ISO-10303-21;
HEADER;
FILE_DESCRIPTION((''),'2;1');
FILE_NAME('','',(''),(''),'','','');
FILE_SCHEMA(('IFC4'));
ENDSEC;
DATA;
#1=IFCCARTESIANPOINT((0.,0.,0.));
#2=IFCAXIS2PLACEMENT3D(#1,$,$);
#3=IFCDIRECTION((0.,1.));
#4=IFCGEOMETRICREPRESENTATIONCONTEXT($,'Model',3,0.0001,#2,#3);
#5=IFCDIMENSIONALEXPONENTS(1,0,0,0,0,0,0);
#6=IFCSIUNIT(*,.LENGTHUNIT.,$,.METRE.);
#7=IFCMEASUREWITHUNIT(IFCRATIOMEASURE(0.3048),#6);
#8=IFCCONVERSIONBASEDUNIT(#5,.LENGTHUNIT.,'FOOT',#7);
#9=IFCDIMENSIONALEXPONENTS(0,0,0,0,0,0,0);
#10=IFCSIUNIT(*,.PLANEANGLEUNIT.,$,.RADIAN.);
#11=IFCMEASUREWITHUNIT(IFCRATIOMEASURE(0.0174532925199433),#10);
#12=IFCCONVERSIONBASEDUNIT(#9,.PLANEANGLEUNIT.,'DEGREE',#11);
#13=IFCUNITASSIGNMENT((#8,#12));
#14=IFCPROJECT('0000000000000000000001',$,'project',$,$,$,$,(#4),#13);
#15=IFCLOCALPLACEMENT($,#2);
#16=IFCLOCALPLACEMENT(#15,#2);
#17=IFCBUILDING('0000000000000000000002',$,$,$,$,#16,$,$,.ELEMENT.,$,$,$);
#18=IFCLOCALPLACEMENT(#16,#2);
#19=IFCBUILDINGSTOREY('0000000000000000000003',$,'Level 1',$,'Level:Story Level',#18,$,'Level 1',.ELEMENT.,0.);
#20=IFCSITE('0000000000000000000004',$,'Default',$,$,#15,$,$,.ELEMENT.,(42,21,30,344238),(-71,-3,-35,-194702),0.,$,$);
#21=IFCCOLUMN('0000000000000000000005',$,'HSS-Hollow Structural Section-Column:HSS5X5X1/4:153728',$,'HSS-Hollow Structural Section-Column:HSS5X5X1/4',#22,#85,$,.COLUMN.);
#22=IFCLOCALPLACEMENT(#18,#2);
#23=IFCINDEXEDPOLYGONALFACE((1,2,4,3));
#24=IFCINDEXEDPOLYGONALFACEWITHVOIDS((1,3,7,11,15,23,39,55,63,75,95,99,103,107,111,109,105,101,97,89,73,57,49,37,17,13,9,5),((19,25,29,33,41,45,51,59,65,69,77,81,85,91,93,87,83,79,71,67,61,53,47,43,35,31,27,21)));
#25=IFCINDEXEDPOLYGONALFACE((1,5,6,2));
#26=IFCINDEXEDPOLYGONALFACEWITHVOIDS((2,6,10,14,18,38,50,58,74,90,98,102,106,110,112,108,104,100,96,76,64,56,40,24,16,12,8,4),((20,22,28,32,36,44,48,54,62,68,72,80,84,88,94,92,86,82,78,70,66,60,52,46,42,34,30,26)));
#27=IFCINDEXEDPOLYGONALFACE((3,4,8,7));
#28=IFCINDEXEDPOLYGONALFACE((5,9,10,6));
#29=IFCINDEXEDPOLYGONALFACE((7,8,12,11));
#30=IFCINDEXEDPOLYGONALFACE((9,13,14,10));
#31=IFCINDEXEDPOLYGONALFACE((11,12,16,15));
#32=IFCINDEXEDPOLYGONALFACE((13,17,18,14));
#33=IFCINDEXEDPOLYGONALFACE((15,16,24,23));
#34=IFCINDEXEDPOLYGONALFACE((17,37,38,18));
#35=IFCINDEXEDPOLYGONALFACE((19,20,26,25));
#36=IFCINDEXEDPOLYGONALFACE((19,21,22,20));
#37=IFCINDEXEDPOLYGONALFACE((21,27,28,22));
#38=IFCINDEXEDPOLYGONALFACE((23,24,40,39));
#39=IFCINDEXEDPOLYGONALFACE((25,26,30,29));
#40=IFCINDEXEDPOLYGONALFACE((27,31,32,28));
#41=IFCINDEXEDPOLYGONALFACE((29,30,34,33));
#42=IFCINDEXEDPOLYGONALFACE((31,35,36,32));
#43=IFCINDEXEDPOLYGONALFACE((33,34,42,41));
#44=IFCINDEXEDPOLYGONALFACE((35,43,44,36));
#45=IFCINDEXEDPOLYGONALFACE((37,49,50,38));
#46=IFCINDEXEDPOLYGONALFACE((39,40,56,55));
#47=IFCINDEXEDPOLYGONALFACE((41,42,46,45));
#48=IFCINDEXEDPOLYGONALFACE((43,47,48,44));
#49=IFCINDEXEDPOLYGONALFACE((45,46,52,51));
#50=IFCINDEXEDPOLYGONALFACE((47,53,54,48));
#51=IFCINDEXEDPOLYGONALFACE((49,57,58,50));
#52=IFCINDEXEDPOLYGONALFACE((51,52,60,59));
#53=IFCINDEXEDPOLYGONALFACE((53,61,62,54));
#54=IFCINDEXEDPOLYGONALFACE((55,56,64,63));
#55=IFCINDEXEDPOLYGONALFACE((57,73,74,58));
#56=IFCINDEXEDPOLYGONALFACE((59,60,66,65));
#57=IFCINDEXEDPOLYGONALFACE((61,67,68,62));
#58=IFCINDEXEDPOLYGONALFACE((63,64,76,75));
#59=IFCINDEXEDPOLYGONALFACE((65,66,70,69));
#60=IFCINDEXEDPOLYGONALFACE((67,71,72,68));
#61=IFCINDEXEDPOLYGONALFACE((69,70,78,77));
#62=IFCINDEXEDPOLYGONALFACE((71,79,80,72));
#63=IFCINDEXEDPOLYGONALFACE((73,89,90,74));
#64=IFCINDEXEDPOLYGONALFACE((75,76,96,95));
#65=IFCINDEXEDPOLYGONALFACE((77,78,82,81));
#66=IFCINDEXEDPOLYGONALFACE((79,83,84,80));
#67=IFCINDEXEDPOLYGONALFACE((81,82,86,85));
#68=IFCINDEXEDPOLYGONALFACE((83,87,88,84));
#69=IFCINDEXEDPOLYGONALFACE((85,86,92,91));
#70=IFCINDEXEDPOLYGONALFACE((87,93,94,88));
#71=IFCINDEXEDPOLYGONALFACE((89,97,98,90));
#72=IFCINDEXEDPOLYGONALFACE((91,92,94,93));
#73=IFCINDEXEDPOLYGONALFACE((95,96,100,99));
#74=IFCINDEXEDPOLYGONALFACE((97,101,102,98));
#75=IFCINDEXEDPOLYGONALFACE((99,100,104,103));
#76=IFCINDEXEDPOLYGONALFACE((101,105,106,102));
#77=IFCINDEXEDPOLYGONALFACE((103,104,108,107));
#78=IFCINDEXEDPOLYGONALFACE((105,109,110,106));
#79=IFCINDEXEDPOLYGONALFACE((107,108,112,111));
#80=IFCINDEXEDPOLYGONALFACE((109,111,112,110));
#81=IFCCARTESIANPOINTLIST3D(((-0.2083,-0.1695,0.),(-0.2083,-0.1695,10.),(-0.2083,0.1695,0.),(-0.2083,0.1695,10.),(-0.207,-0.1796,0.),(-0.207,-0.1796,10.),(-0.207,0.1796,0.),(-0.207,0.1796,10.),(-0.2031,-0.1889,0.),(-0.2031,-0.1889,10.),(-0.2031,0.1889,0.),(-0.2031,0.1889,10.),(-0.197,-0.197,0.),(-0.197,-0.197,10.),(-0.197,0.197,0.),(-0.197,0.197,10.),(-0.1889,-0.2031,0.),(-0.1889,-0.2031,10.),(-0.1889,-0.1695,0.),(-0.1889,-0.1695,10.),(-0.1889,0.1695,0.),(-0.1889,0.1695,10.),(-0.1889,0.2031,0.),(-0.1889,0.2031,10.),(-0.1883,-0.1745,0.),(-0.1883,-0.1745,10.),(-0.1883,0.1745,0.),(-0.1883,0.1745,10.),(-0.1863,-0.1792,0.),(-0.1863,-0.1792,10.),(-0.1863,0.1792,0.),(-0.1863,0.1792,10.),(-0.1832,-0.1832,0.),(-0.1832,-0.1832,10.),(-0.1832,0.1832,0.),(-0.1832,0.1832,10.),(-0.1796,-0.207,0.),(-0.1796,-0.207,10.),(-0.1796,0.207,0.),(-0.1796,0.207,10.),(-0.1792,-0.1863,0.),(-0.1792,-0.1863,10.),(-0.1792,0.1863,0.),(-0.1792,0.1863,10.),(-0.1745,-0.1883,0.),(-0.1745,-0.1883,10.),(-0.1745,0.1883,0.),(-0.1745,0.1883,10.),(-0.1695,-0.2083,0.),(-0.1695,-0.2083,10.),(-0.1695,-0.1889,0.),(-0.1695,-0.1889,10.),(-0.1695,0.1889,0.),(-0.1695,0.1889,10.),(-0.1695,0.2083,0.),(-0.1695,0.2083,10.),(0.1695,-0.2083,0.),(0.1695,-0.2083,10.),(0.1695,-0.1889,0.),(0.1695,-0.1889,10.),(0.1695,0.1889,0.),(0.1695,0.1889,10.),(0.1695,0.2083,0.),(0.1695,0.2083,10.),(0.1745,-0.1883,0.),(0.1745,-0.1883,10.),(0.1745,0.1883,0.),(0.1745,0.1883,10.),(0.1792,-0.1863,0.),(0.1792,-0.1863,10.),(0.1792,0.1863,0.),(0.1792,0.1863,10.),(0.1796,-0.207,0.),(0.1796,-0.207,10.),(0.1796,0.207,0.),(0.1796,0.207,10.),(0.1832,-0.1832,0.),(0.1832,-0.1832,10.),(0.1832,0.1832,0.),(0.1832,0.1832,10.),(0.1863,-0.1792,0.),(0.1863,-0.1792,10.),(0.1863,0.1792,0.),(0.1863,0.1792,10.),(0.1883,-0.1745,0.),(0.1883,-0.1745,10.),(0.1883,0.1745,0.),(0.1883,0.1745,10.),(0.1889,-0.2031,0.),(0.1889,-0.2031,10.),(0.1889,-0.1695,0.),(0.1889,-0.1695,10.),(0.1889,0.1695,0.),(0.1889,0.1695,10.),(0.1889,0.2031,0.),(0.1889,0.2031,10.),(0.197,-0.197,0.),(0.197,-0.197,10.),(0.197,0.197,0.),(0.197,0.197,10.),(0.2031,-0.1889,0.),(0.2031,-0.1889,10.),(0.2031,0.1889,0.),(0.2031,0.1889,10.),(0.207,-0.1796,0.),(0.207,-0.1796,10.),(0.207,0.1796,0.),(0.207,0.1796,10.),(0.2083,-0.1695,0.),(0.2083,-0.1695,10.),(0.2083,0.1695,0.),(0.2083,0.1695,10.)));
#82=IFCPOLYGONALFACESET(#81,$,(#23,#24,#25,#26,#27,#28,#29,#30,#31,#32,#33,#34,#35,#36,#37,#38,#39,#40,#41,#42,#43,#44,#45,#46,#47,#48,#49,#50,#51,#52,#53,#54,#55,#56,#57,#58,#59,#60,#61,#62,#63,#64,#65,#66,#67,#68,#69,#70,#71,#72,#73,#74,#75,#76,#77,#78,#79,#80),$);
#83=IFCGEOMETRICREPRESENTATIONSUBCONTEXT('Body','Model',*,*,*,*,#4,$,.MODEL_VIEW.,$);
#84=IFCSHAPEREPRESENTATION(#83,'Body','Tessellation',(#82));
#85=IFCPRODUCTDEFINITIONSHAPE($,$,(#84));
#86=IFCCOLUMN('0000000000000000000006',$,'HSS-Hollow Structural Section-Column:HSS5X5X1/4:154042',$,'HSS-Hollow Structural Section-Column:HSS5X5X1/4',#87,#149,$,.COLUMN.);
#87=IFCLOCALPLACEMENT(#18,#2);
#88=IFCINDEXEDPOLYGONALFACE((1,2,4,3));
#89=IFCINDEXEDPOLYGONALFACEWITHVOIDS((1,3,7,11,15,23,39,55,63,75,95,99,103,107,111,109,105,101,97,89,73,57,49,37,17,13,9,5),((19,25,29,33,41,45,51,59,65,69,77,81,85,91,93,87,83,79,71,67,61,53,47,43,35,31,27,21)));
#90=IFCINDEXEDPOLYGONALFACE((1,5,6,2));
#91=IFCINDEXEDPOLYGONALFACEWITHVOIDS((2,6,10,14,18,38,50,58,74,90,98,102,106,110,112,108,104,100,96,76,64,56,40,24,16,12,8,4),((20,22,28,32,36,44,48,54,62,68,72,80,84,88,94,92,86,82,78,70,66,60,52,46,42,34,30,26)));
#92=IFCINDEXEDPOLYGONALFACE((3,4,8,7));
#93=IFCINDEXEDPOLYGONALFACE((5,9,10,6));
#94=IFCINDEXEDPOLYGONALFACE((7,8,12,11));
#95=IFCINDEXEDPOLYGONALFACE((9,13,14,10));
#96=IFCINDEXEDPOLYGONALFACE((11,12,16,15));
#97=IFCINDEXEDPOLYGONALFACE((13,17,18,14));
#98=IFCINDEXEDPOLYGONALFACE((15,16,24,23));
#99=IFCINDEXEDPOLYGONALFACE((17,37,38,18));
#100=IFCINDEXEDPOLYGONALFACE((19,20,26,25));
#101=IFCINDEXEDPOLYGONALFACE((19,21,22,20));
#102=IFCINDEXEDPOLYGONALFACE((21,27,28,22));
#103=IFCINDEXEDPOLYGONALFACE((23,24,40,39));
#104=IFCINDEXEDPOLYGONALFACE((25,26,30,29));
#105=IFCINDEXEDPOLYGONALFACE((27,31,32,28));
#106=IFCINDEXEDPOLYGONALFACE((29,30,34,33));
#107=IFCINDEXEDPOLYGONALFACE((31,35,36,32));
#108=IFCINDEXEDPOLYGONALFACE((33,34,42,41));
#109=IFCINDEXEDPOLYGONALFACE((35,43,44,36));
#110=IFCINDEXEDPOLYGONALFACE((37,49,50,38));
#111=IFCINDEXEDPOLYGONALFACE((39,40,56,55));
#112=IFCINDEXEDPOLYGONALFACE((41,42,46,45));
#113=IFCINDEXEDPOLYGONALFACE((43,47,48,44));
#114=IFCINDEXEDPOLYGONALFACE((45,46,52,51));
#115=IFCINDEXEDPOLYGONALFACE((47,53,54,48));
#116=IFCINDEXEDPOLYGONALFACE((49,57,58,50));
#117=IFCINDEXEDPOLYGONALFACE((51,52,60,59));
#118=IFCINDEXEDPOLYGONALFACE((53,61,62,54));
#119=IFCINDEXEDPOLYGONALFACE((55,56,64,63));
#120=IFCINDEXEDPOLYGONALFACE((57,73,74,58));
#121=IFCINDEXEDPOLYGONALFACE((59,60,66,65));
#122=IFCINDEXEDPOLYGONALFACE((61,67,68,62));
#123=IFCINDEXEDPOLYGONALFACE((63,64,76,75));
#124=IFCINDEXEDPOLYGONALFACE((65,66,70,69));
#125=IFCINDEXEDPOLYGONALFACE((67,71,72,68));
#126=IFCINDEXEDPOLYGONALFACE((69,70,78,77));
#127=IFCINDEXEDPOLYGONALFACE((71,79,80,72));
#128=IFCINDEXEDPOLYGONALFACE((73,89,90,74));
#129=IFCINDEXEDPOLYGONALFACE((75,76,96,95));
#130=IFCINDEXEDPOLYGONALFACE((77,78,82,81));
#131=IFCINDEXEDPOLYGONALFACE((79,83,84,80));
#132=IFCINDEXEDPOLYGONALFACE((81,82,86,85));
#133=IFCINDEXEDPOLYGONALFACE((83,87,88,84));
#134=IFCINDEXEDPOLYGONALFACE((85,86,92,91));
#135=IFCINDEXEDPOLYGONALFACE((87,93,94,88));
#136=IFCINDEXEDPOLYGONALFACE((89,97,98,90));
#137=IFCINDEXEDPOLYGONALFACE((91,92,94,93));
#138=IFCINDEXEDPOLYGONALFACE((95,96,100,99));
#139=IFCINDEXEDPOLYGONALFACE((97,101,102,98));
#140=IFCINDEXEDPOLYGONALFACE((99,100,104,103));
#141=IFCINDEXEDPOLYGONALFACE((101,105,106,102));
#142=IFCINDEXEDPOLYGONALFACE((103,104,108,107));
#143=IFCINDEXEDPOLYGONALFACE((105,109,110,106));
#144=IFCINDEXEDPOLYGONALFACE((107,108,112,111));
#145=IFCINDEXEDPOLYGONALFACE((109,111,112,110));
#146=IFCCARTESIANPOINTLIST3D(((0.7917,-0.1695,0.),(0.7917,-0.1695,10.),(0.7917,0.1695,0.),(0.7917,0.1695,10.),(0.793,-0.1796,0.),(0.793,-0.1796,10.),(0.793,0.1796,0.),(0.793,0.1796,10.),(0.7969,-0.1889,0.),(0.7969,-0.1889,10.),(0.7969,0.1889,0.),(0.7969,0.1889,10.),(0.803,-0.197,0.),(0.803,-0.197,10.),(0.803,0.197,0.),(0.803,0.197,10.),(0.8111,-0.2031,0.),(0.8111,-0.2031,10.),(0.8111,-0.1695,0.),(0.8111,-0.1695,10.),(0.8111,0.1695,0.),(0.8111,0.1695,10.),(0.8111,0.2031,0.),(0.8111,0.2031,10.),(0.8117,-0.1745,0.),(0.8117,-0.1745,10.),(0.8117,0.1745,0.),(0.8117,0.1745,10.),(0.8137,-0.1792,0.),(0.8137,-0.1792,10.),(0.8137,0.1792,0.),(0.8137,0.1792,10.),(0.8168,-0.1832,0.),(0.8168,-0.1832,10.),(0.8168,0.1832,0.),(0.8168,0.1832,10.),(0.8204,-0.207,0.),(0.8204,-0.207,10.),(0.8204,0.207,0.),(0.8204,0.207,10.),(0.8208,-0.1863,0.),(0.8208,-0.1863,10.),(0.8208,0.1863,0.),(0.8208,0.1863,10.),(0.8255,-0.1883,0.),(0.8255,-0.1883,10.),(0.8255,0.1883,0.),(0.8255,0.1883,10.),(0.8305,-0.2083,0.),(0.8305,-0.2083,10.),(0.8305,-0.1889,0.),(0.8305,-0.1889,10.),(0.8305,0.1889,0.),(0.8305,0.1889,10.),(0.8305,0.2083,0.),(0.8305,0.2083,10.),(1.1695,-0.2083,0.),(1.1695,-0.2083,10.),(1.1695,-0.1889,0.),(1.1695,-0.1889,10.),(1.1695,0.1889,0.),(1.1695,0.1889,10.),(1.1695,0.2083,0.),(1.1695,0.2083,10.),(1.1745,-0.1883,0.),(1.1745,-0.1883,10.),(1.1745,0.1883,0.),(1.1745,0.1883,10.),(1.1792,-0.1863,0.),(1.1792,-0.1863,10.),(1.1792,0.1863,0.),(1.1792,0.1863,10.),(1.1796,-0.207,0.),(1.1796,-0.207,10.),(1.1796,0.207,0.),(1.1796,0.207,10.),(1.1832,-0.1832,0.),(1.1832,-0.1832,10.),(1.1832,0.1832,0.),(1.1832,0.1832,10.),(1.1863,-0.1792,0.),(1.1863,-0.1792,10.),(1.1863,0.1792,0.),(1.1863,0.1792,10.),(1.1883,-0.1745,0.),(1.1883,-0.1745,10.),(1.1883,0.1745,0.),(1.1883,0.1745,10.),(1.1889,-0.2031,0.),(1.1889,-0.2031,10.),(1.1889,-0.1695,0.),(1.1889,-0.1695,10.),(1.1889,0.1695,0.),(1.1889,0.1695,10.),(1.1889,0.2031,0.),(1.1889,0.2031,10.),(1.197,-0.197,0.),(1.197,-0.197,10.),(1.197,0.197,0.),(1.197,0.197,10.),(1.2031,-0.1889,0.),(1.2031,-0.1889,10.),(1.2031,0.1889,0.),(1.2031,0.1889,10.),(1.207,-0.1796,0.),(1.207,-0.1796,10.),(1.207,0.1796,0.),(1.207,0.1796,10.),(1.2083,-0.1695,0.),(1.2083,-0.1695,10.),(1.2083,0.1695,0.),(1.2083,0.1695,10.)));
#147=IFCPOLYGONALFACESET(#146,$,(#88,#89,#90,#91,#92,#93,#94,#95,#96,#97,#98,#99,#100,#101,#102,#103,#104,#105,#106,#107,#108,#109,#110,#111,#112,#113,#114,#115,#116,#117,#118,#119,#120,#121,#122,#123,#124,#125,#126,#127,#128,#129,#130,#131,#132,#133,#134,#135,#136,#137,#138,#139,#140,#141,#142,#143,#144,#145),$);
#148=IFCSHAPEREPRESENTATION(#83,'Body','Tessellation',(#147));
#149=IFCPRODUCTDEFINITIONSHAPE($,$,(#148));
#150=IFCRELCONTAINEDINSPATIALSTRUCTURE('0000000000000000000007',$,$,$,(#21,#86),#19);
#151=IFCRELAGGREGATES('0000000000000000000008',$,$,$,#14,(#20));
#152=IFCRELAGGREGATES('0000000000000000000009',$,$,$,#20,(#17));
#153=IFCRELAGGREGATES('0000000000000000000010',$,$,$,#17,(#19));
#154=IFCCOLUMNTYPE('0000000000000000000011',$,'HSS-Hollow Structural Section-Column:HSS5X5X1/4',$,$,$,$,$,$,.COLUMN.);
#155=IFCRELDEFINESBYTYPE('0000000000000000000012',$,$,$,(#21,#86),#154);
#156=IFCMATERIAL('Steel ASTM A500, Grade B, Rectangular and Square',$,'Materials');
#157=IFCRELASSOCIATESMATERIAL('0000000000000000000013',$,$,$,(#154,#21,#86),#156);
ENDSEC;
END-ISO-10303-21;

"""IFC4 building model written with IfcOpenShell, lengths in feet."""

from ifc_helpers import new_model, entity, si_unit, converted_unit, direction, frame, frame_2d, origin, place, context, subcontext, project, spatial, polyline, circle_curve, parameter, trimmed, segment, composite_curve, outline, extrude, source, transform, mapped, material, material_profile, profile_set, profile_usage, type_object, type_shapes, element, save


model = new_model("IFC4")

# Units and contexts
model_context = context("Model", 3, precision=0.0001, world=origin(), true_north=direction((0.0, 1.0)))
body_context = subcontext(model_context, "Body", "Model", "MODEL_VIEW")
ifc_project = project(units=[converted_unit("LENGTHUNIT", "FOOT", entity("IfcRatioMeasure", 0.3048), si_unit("LENGTHUNIT", "METRE"), dimensions=[1, 0, 0, 0, 0, 0, 0]), converted_unit("PLANEANGLEUNIT", "DEGREE", entity("IfcRatioMeasure", 0.0174532925199433), si_unit("PLANEANGLEUNIT", "RADIAN"), dimensions=[0, 0, 0, 0, 0, 0, 0])], contexts=[model_context])

# Site, building, storey
site_placement = place(None, origin())
site = spatial("IfcSite", under=ifc_project, at=site_placement, Name="Default", CompositionType="ELEMENT", RefLatitude=(42, 21, 30, 344238), RefLongitude=(-71, -3, -35, -194702), RefElevation=0.0)
building_placement = place(site_placement, origin())
building = spatial("IfcBuilding", under=site, at=building_placement, CompositionType="ELEMENT")
storey_placement = place(building_placement, origin())
storey = spatial("IfcBuildingStorey", under=building, at=storey_placement, Name="Level 1", ObjectType="Level:Story Level", LongName="Level 1", CompositionType="ELEMENT", Elevation=0.0)

# Columns
ifc_material = material(Name="Steel ASTM A500, Grade B, Rectangular and Square", Category="Materials")
ifc_material_profile = material_profile(ifc_material, outline(composite_curve([segment(polyline([(-0.1695, -0.2083), (0.1695, -0.2083)]), True, "CONTINUOUS"), segment(trimmed(circle_curve(frame_2d((0.1695, -0.1695), x_axis=(-1.0, 0.0)), 0.0388), [parameter(90.0)], [parameter(180.0)], True, "PARAMETER"), True, "CONTINUOUS"), segment(polyline([(0.2083, -0.1695), (0.2083, 0.1695)]), True, "CONTINUOUS"), segment(trimmed(circle_curve(frame_2d((0.1695, 0.1695), x_axis=(-1.0, 0.0)), 0.0388), [parameter(180.0)], [parameter(270.0)], True, "PARAMETER"), True, "CONTINUOUS"), segment(polyline([(0.1695, 0.2083), (-0.1695, 0.2083)]), True, "CONTINUOUS"), segment(trimmed(circle_curve(frame_2d((-0.1695, 0.1695), x_axis=(-1.0, 0.0)), 0.0388), [parameter(270.0)], [parameter(360.0)], True, "PARAMETER"), True, "CONTINUOUS"), segment(polyline([(-0.2083, 0.1695), (-0.2083, -0.1695)]), True, "CONTINUOUS"), segment(trimmed(circle_curve(frame_2d((-0.1695, -0.1695), x_axis=(-1.0, 0.0)), 0.0388), [parameter(360.0)], [parameter(90.0)], True, "PARAMETER"), True, "CONTINUOUS")], self_intersect=False), holes=[composite_curve([segment(trimmed(circle_curve(frame_2d((-0.1695, -0.1695), x_axis=(-1.0, 0.0)), 0.0194), [parameter(0.0)], [parameter(90.0)], True, "PARAMETER"), False, "CONTINUOUS"), segment(polyline([(-0.1889, -0.1695), (-0.1889, 0.1695)]), True, "CONTINUOUS"), segment(trimmed(circle_curve(frame_2d((-0.1695, 0.1695), x_axis=(-1.0, 0.0)), 0.0194), [parameter(270.0)], [parameter(360.0)], True, "PARAMETER"), False, "CONTINUOUS"), segment(polyline([(-0.1695, 0.1889), (0.1695, 0.1889)]), True, "CONTINUOUS"), segment(trimmed(circle_curve(frame_2d((0.1695, 0.1695), x_axis=(-1.0, 0.0)), 0.0194), [parameter(180.0)], [parameter(270.0)], True, "PARAMETER"), False, "CONTINUOUS"), segment(polyline([(0.1889, 0.1695), (0.1889, -0.1695)]), True, "CONTINUOUS"), segment(trimmed(circle_curve(frame_2d((0.1695, -0.1695), x_axis=(-1.0, 0.0)), 0.0194), [parameter(90.0)], [parameter(180.0)], True, "PARAMETER"), False, "CONTINUOUS"), segment(polyline([(0.1695, -0.1889), (-0.1695, -0.1889)]), True, "CONTINUOUS")], self_intersect=False)]), Name="HSS5X5X1/4")
ifc_profile_set = profile_set([ifc_material_profile], Name="HSS5X5X1/4")
ifc_profile_usage_1 = profile_usage(ifc_profile_set)
column_type = type_object("IfcColumnType", Name="HSS-Hollow Structural Section-Column:HSS5X5X1/4", PredefinedType="COLUMN", material=ifc_profile_set)
shared_shape = source(origin(), body_context, "Body", "SweptSolid", [
    extrude(outline(composite_curve([segment(polyline([(-0.1695, -0.2083), (0.1695, -0.2083)]), True, "CONTINUOUS"), segment(trimmed(circle_curve(frame_2d((0.1695, -0.1695), x_axis=(-1.0, 0.0)), 0.0388), [parameter(90.0)], [parameter(180.0)], True, "PARAMETER"), True, "CONTINUOUS"), segment(polyline([(0.2083, -0.1695), (0.2083, 0.1695)]), True, "CONTINUOUS"), segment(trimmed(circle_curve(frame_2d((0.1695, 0.1695), x_axis=(-1.0, 0.0)), 0.0388), [parameter(180.0)], [parameter(270.0)], True, "PARAMETER"), True, "CONTINUOUS"), segment(polyline([(0.1695, 0.2083), (-0.1695, 0.2083)]), True, "CONTINUOUS"), segment(trimmed(circle_curve(frame_2d((-0.1695, 0.1695), x_axis=(-1.0, 0.0)), 0.0388), [parameter(270.0)], [parameter(360.0)], True, "PARAMETER"), True, "CONTINUOUS"), segment(polyline([(-0.2083, 0.1695), (-0.2083, -0.1695)]), True, "CONTINUOUS"), segment(trimmed(circle_curve(frame_2d((-0.1695, -0.1695), x_axis=(-1.0, 0.0)), 0.0388), [parameter(360.0)], [parameter(90.0)], True, "PARAMETER"), True, "CONTINUOUS")], self_intersect=False), holes=[composite_curve([segment(trimmed(circle_curve(frame_2d((-0.1695, -0.1695), x_axis=(-1.0, 0.0)), 0.0194), [parameter(0.0)], [parameter(90.0)], True, "PARAMETER"), False, "CONTINUOUS"), segment(polyline([(-0.1889, -0.1695), (-0.1889, 0.1695)]), True, "CONTINUOUS"), segment(trimmed(circle_curve(frame_2d((-0.1695, 0.1695), x_axis=(-1.0, 0.0)), 0.0194), [parameter(270.0)], [parameter(360.0)], True, "PARAMETER"), False, "CONTINUOUS"), segment(polyline([(-0.1695, 0.1889), (0.1695, 0.1889)]), True, "CONTINUOUS"), segment(trimmed(circle_curve(frame_2d((0.1695, 0.1695), x_axis=(-1.0, 0.0)), 0.0194), [parameter(180.0)], [parameter(270.0)], True, "PARAMETER"), False, "CONTINUOUS"), segment(polyline([(0.1889, 0.1695), (0.1889, -0.1695)]), True, "CONTINUOUS"), segment(trimmed(circle_curve(frame_2d((0.1695, -0.1695), x_axis=(-1.0, 0.0)), 0.0194), [parameter(90.0)], [parameter(180.0)], True, "PARAMETER"), False, "CONTINUOUS"), segment(polyline([(0.1695, -0.1889), (-0.1695, -0.1889)]), True, "CONTINUOUS")], self_intersect=False)]), frame((0.0, 0.0, 0.0), z_axis=(0.0, 0.0, 1.0), x_axis=(-1.0, 0.0, 0.0)), (0.0, 0.0, 1.0), 10.0),
])
type_shapes(column_type, [shared_shape])
column_1_placement = place(storey_placement, origin())
element("IfcColumn", 1, at=column_1_placement, inside=storey, type_object=column_type, material=ifc_profile_usage_1, Name="HSS-Hollow Structural Section-Column:HSS5X5X1/4:153728", ObjectType="HSS-Hollow Structural Section-Column:HSS5X5X1/4", PredefinedType="COLUMN", context=body_context, shape_type="MappedRepresentation", body=[
    mapped(shared_shape, transform((0.0, 0.0, 0.0), scale=1.0)),
])
ifc_profile_usage_2 = profile_usage(ifc_profile_set)
column_2_placement = place(storey_placement, frame((1.0, 0.0, 0.0)))
element("IfcColumn", 2, at=column_2_placement, inside=storey, type_object=column_type, material=ifc_profile_usage_2, Name="HSS-Hollow Structural Section-Column:HSS5X5X1/4:154042", ObjectType="HSS-Hollow Structural Section-Column:HSS5X5X1/4", PredefinedType="COLUMN", context=body_context, shape_type="MappedRepresentation", body=[
    mapped(shared_shape, transform((0.0, 0.0, 0.0), scale=1.0)),
])

save(model, "model.ifc")
